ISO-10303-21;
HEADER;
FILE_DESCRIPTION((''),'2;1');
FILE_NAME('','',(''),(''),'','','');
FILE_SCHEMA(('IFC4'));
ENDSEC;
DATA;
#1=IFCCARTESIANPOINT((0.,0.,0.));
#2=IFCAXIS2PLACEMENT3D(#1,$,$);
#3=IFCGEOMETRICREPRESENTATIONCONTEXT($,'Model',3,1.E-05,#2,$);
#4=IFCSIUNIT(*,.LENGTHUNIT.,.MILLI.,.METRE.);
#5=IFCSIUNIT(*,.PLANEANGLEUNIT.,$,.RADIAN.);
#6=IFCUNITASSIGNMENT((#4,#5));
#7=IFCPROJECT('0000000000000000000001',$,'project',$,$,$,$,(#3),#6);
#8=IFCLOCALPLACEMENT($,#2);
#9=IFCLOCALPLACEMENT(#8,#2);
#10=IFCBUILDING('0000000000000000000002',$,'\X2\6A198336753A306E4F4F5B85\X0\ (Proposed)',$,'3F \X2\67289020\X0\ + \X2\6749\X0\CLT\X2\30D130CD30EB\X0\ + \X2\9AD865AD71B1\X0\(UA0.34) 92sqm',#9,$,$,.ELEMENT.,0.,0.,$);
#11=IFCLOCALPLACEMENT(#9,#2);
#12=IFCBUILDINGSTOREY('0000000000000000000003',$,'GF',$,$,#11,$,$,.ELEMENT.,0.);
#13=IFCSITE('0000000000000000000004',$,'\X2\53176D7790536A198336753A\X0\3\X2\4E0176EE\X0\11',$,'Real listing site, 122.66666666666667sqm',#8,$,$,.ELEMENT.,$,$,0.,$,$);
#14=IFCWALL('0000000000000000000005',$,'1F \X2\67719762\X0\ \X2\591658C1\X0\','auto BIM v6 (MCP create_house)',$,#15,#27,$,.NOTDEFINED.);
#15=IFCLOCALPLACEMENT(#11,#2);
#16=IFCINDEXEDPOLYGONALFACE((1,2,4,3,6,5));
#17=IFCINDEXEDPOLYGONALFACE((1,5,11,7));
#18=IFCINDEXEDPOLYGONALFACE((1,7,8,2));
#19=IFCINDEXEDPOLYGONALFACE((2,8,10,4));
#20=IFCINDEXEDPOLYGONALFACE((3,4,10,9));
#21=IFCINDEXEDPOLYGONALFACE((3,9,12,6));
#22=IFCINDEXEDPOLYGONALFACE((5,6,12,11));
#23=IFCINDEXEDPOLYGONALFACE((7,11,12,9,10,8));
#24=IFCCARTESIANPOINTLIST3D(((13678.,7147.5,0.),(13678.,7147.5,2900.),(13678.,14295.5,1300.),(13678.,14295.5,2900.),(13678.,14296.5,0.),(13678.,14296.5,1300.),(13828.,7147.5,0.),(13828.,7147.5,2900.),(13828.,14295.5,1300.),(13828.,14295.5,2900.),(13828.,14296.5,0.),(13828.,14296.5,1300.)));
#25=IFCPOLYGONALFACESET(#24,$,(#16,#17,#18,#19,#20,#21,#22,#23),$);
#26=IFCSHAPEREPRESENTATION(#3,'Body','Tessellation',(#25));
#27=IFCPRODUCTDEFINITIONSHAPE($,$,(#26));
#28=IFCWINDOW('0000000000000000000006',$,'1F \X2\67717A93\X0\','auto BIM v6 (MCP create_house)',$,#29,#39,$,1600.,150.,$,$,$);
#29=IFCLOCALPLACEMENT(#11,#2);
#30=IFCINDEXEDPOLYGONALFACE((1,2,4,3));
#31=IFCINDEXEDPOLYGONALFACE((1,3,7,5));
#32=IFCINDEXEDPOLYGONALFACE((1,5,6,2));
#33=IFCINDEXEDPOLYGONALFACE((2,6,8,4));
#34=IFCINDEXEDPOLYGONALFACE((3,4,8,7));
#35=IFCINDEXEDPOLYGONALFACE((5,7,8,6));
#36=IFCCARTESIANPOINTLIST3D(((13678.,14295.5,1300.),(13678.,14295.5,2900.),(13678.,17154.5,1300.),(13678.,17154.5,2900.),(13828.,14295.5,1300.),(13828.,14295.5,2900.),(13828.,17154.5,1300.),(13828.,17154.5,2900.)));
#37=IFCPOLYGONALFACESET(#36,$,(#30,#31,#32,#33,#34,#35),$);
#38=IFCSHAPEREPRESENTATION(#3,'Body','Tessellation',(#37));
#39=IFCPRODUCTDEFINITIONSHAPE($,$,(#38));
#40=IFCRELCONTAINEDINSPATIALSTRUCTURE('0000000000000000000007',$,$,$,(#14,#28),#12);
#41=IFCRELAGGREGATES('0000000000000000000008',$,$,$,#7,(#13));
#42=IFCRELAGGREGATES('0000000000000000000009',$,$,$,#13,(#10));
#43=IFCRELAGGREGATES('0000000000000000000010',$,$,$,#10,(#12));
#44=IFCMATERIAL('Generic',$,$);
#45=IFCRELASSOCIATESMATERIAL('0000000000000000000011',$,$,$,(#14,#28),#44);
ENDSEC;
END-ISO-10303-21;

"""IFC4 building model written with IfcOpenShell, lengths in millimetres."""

from ifc_helpers import new_model, si_unit, frame, frame_2d, origin, place, context, project, spatial, rectangle, extrude, material, element, fill, save


model = new_model("IFC4")

# Units and contexts
model_context = context("Model", 3, precision=1e-05, world=origin())
ifc_project = project(units=[si_unit("LENGTHUNIT", "METRE", prefix="MILLI"), si_unit("PLANEANGLEUNIT", "RADIAN")], contexts=[model_context])

# Site, building, storey
site_placement = place(None, origin())
site = spatial("IfcSite", under=ifc_project, at=site_placement, Name="北海道標茶町3丁目11", ObjectType="Real listing site, 122.66666666666667sqm", CompositionType="ELEMENT", RefElevation=0.0)
building_placement = place(site_placement, origin())
building = spatial("IfcBuilding", under=site, at=building_placement, Name="標茶町の住宅 (Proposed)", ObjectType="3F 木造 + 杉CLTパネル + 高断熱(UA0.34) 92sqm", CompositionType="ELEMENT", ElevationOfRefHeight=0.0, ElevationOfTerrain=0.0)
storey_placement = place(building_placement, origin())
storey = spatial("IfcBuildingStorey", under=building, at=storey_placement, Name="GF", CompositionType="ELEMENT", Elevation=0.0)

# Shared definitions
ifc_material = material(Name="Generic")

# Wall, opening, window
wall_1_placement = place(storey_placement, frame((6839.0, 3574.0, 0.0)))
wall_1 = element("IfcWall", 1, at=wall_1_placement, inside=storey, material=ifc_material, Name="1F 東面 外壁", Description="auto BIM v6 (MCP create_house)", PredefinedType="NOTDEFINED", context=model_context, shape_type="SweptSolid", body=[
    extrude(rectangle(XDim=150.0, YDim=7149.0, at=frame_2d((75.0, 3574.0))), frame((6839.0, 3574.0, 0.0)), (0.0, 0.0, 1.0), 2900.0),
])
opening_1_placement = place(storey_placement, frame((6839.0, 7148.0, 650.0)))
opening_1 = element("IfcOpeningElement", 2, at=opening_1_placement, cuts=wall_1, PredefinedType="NOTDEFINED", context=model_context, shape_type="SweptSolid", body=[
    extrude(rectangle(XDim=150.0, YDim=2859.0, at=frame_2d((75.0, 1429.0))), frame((6839.0, 7148.0, 650.0)), (0.0, 0.0, 1.0), 1600.0),
])
window_1_placement = place(storey_placement, frame((6839.0, 7148.0, 650.0)))
window_1 = element("IfcWindow", 3, at=window_1_placement, inside=storey, material=ifc_material, Name="1F 東窓", Description="auto BIM v6 (MCP create_house)", OverallHeight=1600.0, OverallWidth=150.0, context=model_context, shape_type="SweptSolid", body=[
    extrude(rectangle(XDim=150.0, YDim=2859.0, at=frame_2d((75.0, 1429.0))), frame((6839.0, 7148.0, 650.0)), (0.0, 0.0, 1.0), 1600.0),
])
fill(opening_1, window_1)

save(model, "model.ifc")
